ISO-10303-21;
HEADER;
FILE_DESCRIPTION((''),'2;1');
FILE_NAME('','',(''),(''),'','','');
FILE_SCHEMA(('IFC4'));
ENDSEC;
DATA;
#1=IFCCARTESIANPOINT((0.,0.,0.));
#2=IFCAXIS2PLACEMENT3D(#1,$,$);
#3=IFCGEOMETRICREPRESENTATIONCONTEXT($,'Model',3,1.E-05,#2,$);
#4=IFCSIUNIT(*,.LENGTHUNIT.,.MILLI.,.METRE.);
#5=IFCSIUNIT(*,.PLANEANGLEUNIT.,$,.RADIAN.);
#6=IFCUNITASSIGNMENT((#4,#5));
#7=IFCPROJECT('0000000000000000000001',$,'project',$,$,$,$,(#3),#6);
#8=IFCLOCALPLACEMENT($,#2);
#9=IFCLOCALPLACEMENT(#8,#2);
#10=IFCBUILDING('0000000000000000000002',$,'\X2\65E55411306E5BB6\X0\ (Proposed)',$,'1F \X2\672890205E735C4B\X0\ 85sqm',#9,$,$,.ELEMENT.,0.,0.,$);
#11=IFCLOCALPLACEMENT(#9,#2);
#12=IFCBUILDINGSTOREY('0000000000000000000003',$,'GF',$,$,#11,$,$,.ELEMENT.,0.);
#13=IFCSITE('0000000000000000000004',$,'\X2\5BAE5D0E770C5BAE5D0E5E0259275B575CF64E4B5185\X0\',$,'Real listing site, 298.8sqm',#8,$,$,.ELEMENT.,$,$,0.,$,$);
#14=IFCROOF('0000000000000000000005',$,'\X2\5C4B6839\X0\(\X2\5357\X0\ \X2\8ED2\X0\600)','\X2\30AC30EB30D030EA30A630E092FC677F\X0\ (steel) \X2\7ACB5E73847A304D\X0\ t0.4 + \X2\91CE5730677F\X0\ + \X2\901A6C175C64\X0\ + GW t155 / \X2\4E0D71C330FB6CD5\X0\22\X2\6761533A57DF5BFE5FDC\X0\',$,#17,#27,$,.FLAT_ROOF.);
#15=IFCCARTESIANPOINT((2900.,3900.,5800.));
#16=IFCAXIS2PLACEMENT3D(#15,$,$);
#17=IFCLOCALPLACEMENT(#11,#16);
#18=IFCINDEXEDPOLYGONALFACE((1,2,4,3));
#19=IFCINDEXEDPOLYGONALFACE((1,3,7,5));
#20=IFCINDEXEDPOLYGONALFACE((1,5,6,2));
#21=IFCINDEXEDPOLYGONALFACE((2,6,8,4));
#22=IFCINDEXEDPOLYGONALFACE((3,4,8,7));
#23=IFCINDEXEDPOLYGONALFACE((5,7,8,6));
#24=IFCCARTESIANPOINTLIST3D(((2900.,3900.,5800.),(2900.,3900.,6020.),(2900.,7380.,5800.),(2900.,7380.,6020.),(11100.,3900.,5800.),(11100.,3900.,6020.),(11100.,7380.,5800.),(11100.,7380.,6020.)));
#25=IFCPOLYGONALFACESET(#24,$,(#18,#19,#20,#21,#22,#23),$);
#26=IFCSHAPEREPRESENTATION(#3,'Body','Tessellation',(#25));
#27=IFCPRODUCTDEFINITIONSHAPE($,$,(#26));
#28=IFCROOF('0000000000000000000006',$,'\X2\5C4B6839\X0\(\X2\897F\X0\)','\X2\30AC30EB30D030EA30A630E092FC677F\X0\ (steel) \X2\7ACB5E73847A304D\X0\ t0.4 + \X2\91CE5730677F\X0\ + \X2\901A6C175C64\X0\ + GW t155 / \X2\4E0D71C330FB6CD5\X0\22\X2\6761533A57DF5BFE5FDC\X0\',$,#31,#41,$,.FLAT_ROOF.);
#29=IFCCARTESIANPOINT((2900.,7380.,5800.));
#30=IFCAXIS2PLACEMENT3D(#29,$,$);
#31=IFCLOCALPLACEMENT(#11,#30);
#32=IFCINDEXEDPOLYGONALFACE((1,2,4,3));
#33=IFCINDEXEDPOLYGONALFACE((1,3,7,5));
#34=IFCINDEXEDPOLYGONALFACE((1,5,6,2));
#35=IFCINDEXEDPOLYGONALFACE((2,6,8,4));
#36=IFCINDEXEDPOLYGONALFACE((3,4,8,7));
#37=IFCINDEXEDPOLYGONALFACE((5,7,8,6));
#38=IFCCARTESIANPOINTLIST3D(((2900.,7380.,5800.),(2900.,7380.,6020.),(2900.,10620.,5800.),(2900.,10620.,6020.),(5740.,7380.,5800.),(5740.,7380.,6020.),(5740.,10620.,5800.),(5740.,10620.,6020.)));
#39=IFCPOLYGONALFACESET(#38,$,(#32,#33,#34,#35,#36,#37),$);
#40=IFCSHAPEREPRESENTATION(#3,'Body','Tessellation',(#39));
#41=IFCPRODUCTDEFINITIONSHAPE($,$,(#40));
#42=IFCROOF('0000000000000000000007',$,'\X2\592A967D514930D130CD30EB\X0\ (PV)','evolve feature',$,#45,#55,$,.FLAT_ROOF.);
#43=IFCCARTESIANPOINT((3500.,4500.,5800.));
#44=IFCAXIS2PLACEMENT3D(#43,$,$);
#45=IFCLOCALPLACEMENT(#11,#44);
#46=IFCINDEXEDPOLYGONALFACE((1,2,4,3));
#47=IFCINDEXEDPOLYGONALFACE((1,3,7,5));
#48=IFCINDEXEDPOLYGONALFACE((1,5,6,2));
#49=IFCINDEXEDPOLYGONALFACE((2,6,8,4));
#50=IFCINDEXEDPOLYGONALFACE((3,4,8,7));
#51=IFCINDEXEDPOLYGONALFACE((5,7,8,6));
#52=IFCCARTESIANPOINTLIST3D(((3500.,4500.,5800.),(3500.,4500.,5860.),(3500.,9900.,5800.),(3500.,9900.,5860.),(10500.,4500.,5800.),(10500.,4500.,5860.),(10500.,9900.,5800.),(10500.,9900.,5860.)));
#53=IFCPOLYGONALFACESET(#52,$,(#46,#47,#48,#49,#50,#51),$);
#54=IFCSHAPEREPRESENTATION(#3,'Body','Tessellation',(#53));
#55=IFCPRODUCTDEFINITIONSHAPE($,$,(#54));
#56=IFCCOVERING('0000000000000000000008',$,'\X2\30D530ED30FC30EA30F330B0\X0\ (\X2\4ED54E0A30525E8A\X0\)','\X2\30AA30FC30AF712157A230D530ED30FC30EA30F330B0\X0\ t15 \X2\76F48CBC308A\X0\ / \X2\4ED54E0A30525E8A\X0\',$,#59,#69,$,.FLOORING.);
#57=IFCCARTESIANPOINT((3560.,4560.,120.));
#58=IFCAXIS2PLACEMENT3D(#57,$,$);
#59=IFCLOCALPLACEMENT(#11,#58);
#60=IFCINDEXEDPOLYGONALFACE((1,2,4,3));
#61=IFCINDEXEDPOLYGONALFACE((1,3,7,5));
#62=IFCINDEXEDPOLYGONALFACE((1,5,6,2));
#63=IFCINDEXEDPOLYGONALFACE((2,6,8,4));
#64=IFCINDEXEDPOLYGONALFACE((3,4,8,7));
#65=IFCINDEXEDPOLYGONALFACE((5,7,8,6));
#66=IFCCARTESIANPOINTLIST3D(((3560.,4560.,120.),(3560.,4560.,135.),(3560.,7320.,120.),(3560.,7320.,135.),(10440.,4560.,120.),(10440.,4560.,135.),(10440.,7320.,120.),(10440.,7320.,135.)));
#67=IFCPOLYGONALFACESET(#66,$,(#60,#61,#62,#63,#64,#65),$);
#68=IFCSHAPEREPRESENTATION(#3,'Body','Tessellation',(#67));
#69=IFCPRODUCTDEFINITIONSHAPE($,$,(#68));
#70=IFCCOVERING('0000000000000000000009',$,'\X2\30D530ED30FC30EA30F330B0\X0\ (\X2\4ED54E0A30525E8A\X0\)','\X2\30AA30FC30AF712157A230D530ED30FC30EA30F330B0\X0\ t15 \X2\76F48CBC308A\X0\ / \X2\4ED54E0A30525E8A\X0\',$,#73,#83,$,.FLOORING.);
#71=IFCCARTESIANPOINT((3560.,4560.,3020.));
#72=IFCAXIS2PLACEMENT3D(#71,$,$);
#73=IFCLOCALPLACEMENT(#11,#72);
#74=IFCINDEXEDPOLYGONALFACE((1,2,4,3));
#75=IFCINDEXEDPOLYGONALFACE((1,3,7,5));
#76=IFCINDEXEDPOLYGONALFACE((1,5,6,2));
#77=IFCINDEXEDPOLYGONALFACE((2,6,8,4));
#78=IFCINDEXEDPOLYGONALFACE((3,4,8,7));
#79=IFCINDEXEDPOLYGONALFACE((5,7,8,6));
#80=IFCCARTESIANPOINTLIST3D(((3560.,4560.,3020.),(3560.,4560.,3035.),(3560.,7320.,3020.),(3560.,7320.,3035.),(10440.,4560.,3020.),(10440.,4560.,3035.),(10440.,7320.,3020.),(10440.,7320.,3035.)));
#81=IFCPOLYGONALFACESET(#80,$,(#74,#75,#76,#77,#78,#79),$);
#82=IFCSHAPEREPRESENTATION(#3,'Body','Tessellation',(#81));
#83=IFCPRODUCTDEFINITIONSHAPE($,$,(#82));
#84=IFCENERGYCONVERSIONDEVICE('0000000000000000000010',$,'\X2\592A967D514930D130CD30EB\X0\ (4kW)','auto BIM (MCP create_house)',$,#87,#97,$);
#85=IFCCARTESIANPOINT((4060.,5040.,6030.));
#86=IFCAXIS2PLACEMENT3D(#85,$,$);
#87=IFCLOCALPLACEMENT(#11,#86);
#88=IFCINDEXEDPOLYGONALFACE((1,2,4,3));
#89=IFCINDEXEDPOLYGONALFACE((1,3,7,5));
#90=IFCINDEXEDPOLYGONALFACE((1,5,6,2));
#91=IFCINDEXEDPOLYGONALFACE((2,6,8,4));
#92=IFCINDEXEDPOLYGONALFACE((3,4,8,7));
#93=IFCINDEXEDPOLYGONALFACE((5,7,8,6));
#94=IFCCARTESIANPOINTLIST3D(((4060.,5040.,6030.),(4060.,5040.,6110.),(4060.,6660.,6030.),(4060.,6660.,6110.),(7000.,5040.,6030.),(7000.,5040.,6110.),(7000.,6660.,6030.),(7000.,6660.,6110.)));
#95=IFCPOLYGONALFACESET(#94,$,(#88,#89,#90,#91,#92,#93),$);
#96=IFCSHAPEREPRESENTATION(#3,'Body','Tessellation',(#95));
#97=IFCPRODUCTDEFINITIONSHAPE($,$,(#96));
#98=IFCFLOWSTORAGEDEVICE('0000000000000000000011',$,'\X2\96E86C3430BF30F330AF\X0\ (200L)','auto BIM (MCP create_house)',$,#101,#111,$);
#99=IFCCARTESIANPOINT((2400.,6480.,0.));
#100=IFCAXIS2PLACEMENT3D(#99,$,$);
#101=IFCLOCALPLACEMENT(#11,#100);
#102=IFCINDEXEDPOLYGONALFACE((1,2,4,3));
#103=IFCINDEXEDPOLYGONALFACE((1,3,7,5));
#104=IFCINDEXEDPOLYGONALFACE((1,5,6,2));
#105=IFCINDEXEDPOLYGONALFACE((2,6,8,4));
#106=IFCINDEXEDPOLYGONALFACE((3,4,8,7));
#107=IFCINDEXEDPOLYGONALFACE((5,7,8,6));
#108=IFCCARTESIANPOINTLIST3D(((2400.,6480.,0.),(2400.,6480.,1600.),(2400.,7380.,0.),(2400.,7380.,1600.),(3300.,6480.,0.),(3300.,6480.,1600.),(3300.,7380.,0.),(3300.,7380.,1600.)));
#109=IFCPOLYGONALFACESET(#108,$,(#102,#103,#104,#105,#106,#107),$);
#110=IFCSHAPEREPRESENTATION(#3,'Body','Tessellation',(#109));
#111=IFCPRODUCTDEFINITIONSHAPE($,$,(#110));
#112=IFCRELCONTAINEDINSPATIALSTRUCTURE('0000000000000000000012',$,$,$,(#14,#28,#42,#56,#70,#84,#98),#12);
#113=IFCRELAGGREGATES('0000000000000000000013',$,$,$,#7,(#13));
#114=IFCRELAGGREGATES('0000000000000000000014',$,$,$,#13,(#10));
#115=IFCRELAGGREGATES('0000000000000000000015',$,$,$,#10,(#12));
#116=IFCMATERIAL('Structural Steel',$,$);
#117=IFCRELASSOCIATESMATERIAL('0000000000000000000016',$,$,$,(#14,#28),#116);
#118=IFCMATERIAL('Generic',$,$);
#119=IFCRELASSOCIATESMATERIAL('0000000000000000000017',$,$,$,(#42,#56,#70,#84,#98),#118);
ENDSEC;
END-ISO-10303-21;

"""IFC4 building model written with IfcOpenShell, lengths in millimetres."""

from ifc_helpers import new_model, si_unit, frame, frame_2d, origin, place, context, project, spatial, rectangle, extrude, material, element, save


model = new_model("IFC4")

# Units and contexts
model_context = context("Model", 3, precision=1e-05, world=origin())
ifc_project = project(units=[si_unit("LENGTHUNIT", "METRE", prefix="MILLI"), si_unit("PLANEANGLEUNIT", "RADIAN")], contexts=[model_context])

# Site, building, storey
site_placement = place(None, origin())
site = spatial("IfcSite", under=ifc_project, at=site_placement, Name="宮崎県宮崎市大字島之内", ObjectType="Real listing site, 298.8sqm", CompositionType="ELEMENT", RefElevation=0.0)
building_placement = place(site_placement, origin())
building = spatial("IfcBuilding", under=site, at=building_placement, Name="日向の家 (Proposed)", ObjectType="1F 木造平屋 85sqm", CompositionType="ELEMENT", ElevationOfRefHeight=0.0, ElevationOfTerrain=0.0)
storey_placement = place(building_placement, origin())
storey = spatial("IfcBuildingStorey", under=building, at=storey_placement, Name="GF", CompositionType="ELEMENT", Elevation=0.0)

# Shared definitions
ifc_material_1 = material(Name="Generic")

# Roofs
ifc_material_2 = material(Name="Structural Steel")
roof_1_placement = place(storey_placement, frame((2900.0, 3900.0, 5800.0)))
element("IfcRoof", 1, at=roof_1_placement, inside=storey, material=ifc_material_2, Name="屋根(南 軒600)", Description="ガルバリウム鋼板 (steel) 立平葺き t0.4 + 野地板 + 通気層 + GW t155 / 不燃・法22条区域対応", PredefinedType="FLAT_ROOF", context=model_context, shape_type="SweptSolid", body=[
    extrude(rectangle(XDim=8200.0, YDim=3480.0, at=frame_2d((4100.0, 1740.0))), frame((2900.0, 3900.0, 5800.0)), (0.0, 0.0, 1.0), 220.0),
])
roof_2_placement = place(storey_placement, frame((2900.0, 7380.0, 5800.0)))
element("IfcRoof", 2, at=roof_2_placement, inside=storey, material=ifc_material_2, Name="屋根(西)", Description="ガルバリウム鋼板 (steel) 立平葺き t0.4 + 野地板 + 通気層 + GW t155 / 不燃・法22条区域対応", PredefinedType="FLAT_ROOF", context=model_context, shape_type="SweptSolid", body=[
    extrude(rectangle(XDim=2840.0, YDim=3240.0, at=frame_2d((1420.0, 1620.0))), frame((2900.0, 7380.0, 5800.0)), (0.0, 0.0, 1.0), 220.0),
])
roof_3_placement = place(storey_placement, frame((3500.0, 4500.0, 5800.0)))
element("IfcRoof", 3, at=roof_3_placement, inside=storey, material=ifc_material_1, Name="太陽光パネル (PV)", Description="evolve feature", PredefinedType="FLAT_ROOF", context=model_context, shape_type="SweptSolid", body=[
    extrude(rectangle(XDim=7000.0, YDim=5400.0, at=frame_2d((3500.0, 2700.0))), frame((3500.0, 4500.0, 5800.0)), (0.0, 0.0, 1.0), 60.0),
])

# Coverings
covering_1_placement = place(storey_placement, frame((3560.0, 4560.0, 120.0)))
element("IfcCovering", 4, at=covering_1_placement, inside=storey, material=ifc_material_1, Name="フローリング (仕上げ床)", Description="オーク無垢フローリング t15 直貼り / 仕上げ床", PredefinedType="FLOORING", context=model_context, shape_type="SweptSolid", body=[
    extrude(rectangle(XDim=6880.0, YDim=2760.0, at=frame_2d((3440.0, 1380.0))), frame((3560.0, 4560.0, 120.0)), (0.0, 0.0, 1.0), 15.0),
])
covering_2_placement = place(storey_placement, frame((3560.0, 4560.0, 3020.0)))
element("IfcCovering", 5, at=covering_2_placement, inside=storey, material=ifc_material_1, Name="フローリング (仕上げ床)", Description="オーク無垢フローリング t15 直貼り / 仕上げ床", PredefinedType="FLOORING", context=model_context, shape_type="SweptSolid", body=[
    extrude(rectangle(XDim=6880.0, YDim=2760.0, at=frame_2d((3440.0, 1380.0))), frame((3560.0, 4560.0, 3020.0)), (0.0, 0.0, 1.0), 15.0),
])

# Energy conversion device
energy_conversion_device_placement = place(storey_placement, frame((4060.0, 5040.0, 6030.0)))
element("IfcEnergyConversionDevice", 6, at=energy_conversion_device_placement, inside=storey, material=ifc_material_1, Name="太陽光パネル (4kW)", Description="auto BIM (MCP create_house)", context=model_context, shape_type="SweptSolid", body=[
    extrude(rectangle(XDim=2940.0, YDim=1620.0, at=frame_2d((1470.0, 810.0))), frame((4060.0, 5040.0, 6030.0)), (0.0, 0.0, 1.0), 80.0),
])

# Flow storage device
flow_storage_device_placement = place(storey_placement, frame((2400.0, 6480.0, 0.0)))
element("IfcFlowStorageDevice", 7, at=flow_storage_device_placement, inside=storey, material=ifc_material_1, Name="雨水タンク (200L)", Description="auto BIM (MCP create_house)", context=model_context, shape_type="SweptSolid", body=[
    extrude(rectangle(XDim=900.0, YDim=900.0, at=frame_2d((450.0, 450.0))), frame((2400.0, 6480.0, 0.0)), (0.0, 0.0, 1.0), 1600.0),
])

save(model, "model.ifc")
